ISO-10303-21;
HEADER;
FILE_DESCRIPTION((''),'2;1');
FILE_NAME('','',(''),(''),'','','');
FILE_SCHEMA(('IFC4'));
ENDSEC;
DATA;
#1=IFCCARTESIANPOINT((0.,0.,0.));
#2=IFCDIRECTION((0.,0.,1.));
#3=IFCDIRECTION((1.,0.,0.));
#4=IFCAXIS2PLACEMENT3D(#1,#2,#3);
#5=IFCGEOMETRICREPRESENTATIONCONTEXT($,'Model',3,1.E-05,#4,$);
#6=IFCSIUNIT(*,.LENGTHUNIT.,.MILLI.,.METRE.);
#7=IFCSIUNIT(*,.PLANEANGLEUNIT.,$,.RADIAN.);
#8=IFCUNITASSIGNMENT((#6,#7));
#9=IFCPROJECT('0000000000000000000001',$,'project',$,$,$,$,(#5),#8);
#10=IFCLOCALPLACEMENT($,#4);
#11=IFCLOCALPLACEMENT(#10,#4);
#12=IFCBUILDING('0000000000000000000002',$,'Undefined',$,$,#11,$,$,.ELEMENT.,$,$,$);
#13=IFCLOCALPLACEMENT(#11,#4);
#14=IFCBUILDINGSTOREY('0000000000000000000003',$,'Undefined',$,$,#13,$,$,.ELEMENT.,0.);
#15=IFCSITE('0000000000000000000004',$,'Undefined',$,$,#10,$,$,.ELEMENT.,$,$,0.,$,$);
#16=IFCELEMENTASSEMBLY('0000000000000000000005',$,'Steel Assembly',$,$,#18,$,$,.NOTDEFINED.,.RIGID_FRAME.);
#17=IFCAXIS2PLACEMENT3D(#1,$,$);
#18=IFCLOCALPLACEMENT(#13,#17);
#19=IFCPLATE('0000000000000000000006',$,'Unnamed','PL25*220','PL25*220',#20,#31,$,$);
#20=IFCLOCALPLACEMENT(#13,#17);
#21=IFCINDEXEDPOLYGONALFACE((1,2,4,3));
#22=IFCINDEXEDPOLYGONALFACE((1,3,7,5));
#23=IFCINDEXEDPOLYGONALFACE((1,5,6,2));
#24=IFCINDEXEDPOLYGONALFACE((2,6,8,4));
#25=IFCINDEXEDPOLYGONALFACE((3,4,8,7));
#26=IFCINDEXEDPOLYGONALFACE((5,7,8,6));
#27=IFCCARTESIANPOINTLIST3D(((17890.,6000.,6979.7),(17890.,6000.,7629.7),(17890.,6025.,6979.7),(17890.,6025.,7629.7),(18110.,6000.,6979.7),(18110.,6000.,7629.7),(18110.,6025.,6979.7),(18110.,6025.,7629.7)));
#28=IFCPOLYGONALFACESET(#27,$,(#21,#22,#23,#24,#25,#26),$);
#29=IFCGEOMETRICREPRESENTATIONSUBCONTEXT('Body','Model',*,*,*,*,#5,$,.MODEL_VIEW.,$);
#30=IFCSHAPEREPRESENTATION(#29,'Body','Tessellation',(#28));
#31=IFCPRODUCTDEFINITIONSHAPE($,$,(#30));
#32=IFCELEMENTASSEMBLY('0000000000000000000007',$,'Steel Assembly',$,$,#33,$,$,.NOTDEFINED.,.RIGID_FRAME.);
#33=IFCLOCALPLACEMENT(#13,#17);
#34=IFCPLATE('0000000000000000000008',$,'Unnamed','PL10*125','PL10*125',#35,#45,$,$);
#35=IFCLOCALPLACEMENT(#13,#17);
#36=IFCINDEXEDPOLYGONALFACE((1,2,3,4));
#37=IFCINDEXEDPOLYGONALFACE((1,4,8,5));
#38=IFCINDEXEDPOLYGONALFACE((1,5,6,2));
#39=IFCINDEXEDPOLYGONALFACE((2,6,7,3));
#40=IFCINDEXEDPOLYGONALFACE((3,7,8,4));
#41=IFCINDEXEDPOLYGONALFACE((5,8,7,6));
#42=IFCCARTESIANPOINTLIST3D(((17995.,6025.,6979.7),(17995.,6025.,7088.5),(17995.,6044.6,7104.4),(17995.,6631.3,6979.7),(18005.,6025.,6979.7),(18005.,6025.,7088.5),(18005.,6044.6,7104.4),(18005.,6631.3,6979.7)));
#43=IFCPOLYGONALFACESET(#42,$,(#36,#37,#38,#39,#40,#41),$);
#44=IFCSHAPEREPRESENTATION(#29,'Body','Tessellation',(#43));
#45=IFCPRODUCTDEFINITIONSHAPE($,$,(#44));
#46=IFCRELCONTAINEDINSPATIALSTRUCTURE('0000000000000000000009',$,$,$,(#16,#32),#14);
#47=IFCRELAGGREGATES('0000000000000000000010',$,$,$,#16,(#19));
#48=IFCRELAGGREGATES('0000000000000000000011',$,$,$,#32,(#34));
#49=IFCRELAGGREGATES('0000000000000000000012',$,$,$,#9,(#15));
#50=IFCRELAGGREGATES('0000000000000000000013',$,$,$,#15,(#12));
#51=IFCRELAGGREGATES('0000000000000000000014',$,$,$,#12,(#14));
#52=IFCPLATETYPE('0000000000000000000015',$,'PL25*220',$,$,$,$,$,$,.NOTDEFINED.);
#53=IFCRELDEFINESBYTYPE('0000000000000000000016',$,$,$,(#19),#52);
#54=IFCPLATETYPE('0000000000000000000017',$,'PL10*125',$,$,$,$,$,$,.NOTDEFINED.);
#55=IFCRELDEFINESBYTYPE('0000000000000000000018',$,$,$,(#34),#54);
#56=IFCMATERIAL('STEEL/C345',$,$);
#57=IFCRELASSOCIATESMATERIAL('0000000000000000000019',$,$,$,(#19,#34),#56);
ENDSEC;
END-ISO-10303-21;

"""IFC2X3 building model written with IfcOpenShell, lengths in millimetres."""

from ifc_helpers import new_model, si_unit, frame, origin_with_axes, place, context, subcontext, project, spatial, polyline, outline, extrude, material, type_object, element, aggregate, save


model = new_model("IFC2X3")

# Units and contexts
model_context = context("Model", 3, precision=1e-05, world=origin_with_axes())
body_context = subcontext(model_context, "Body", "Model", "MODEL_VIEW")
ifc_project = project(units=[si_unit("LENGTHUNIT", "METRE", prefix="MILLI"), si_unit("PLANEANGLEUNIT", "RADIAN")], contexts=[model_context])

# Site, building, storey
site_placement = place(None, origin_with_axes())
site = spatial("IfcSite", under=ifc_project, at=site_placement, Name="Undefined", CompositionType="ELEMENT", RefElevation=0.0)
building_placement = place(site_placement, origin_with_axes())
building = spatial("IfcBuilding", under=site, at=building_placement, Name="Undefined", CompositionType="ELEMENT")
storey_placement = place(building_placement, origin_with_axes())
storey = spatial("IfcBuildingStorey", under=building, at=storey_placement, Name="Undefined", CompositionType="ELEMENT", Elevation=0.0)

# Shared definitions
ifc_material = material(Name="STEEL/C345")

# Element assemblies, plates
assembly_1_placement = place(storey_placement, origin_with_axes())
assembly_1 = element("IfcElementAssembly", 1, at=assembly_1_placement, inside=storey, Name="Steel Assembly", AssemblyPlace="NOTDEFINED", PredefinedType="RIGID_FRAME")
plate_type_1 = type_object("IfcPlateType", Name="PL25*220", PredefinedType="NOTDEFINED")
plate_1_placement = place(assembly_1_placement, frame((17890.0, 6012.5, 6979.7), z_axis=(0.0, 1.0, 0.0), x_axis=(0.0, 0.0, 1.0)))
plate_1 = element("IfcPlate", 2, at=plate_1_placement, type_object=plate_type_1, material=ifc_material, Name="Unnamed", Description="PL25*220", ObjectType="PL25*220", context=body_context, shape_type="SweptSolid", body=[
    extrude(outline(polyline([(0.0, 0.0), (650.0, 0.0), (650.0, 220.0), (0.0, 220.0), (0.0, 0.0)])), frame((0.0, 0.0, -12.5), z_axis=(0.0, 0.0, 1.0), x_axis=(1.0, 0.0, 0.0)), (0.0, 0.0, 1.0), 25.0),
])
aggregate(assembly_1, [plate_1])
assembly_2_placement = place(storey_placement, origin_with_axes())
assembly_2 = element("IfcElementAssembly", 3, at=assembly_2_placement, inside=storey, Name="Steel Assembly", AssemblyPlace="NOTDEFINED", PredefinedType="RIGID_FRAME")
plate_type_2 = type_object("IfcPlateType", Name="PL10*125", PredefinedType="NOTDEFINED")
plate_2_placement = place(assembly_2_placement, frame((18000.0, 6631.3, 6979.7), z_axis=(-1.0, 0.0, 0.0), x_axis=(0.0, -1.0, 0.0)))
plate_2 = element("IfcPlate", 4, at=plate_2_placement, type_object=plate_type_2, material=ifc_material, Name="Unnamed", Description="PL10*125", ObjectType="PL10*125", context=body_context, shape_type="SweptSolid", body=[
    extrude(outline(polyline([(0.0, 0.0), (606.3, 0.0), (606.3, 108.8), (586.7, 124.7), (0.0, 0.0)])), frame((0.0, 0.0, -5.0), z_axis=(0.0, 0.0, 1.0), x_axis=(1.0, 0.0, 0.0)), (0.0, 0.0, 1.0), 10.0),
])
aggregate(assembly_2, [plate_2])

save(model, "model.ifc")
